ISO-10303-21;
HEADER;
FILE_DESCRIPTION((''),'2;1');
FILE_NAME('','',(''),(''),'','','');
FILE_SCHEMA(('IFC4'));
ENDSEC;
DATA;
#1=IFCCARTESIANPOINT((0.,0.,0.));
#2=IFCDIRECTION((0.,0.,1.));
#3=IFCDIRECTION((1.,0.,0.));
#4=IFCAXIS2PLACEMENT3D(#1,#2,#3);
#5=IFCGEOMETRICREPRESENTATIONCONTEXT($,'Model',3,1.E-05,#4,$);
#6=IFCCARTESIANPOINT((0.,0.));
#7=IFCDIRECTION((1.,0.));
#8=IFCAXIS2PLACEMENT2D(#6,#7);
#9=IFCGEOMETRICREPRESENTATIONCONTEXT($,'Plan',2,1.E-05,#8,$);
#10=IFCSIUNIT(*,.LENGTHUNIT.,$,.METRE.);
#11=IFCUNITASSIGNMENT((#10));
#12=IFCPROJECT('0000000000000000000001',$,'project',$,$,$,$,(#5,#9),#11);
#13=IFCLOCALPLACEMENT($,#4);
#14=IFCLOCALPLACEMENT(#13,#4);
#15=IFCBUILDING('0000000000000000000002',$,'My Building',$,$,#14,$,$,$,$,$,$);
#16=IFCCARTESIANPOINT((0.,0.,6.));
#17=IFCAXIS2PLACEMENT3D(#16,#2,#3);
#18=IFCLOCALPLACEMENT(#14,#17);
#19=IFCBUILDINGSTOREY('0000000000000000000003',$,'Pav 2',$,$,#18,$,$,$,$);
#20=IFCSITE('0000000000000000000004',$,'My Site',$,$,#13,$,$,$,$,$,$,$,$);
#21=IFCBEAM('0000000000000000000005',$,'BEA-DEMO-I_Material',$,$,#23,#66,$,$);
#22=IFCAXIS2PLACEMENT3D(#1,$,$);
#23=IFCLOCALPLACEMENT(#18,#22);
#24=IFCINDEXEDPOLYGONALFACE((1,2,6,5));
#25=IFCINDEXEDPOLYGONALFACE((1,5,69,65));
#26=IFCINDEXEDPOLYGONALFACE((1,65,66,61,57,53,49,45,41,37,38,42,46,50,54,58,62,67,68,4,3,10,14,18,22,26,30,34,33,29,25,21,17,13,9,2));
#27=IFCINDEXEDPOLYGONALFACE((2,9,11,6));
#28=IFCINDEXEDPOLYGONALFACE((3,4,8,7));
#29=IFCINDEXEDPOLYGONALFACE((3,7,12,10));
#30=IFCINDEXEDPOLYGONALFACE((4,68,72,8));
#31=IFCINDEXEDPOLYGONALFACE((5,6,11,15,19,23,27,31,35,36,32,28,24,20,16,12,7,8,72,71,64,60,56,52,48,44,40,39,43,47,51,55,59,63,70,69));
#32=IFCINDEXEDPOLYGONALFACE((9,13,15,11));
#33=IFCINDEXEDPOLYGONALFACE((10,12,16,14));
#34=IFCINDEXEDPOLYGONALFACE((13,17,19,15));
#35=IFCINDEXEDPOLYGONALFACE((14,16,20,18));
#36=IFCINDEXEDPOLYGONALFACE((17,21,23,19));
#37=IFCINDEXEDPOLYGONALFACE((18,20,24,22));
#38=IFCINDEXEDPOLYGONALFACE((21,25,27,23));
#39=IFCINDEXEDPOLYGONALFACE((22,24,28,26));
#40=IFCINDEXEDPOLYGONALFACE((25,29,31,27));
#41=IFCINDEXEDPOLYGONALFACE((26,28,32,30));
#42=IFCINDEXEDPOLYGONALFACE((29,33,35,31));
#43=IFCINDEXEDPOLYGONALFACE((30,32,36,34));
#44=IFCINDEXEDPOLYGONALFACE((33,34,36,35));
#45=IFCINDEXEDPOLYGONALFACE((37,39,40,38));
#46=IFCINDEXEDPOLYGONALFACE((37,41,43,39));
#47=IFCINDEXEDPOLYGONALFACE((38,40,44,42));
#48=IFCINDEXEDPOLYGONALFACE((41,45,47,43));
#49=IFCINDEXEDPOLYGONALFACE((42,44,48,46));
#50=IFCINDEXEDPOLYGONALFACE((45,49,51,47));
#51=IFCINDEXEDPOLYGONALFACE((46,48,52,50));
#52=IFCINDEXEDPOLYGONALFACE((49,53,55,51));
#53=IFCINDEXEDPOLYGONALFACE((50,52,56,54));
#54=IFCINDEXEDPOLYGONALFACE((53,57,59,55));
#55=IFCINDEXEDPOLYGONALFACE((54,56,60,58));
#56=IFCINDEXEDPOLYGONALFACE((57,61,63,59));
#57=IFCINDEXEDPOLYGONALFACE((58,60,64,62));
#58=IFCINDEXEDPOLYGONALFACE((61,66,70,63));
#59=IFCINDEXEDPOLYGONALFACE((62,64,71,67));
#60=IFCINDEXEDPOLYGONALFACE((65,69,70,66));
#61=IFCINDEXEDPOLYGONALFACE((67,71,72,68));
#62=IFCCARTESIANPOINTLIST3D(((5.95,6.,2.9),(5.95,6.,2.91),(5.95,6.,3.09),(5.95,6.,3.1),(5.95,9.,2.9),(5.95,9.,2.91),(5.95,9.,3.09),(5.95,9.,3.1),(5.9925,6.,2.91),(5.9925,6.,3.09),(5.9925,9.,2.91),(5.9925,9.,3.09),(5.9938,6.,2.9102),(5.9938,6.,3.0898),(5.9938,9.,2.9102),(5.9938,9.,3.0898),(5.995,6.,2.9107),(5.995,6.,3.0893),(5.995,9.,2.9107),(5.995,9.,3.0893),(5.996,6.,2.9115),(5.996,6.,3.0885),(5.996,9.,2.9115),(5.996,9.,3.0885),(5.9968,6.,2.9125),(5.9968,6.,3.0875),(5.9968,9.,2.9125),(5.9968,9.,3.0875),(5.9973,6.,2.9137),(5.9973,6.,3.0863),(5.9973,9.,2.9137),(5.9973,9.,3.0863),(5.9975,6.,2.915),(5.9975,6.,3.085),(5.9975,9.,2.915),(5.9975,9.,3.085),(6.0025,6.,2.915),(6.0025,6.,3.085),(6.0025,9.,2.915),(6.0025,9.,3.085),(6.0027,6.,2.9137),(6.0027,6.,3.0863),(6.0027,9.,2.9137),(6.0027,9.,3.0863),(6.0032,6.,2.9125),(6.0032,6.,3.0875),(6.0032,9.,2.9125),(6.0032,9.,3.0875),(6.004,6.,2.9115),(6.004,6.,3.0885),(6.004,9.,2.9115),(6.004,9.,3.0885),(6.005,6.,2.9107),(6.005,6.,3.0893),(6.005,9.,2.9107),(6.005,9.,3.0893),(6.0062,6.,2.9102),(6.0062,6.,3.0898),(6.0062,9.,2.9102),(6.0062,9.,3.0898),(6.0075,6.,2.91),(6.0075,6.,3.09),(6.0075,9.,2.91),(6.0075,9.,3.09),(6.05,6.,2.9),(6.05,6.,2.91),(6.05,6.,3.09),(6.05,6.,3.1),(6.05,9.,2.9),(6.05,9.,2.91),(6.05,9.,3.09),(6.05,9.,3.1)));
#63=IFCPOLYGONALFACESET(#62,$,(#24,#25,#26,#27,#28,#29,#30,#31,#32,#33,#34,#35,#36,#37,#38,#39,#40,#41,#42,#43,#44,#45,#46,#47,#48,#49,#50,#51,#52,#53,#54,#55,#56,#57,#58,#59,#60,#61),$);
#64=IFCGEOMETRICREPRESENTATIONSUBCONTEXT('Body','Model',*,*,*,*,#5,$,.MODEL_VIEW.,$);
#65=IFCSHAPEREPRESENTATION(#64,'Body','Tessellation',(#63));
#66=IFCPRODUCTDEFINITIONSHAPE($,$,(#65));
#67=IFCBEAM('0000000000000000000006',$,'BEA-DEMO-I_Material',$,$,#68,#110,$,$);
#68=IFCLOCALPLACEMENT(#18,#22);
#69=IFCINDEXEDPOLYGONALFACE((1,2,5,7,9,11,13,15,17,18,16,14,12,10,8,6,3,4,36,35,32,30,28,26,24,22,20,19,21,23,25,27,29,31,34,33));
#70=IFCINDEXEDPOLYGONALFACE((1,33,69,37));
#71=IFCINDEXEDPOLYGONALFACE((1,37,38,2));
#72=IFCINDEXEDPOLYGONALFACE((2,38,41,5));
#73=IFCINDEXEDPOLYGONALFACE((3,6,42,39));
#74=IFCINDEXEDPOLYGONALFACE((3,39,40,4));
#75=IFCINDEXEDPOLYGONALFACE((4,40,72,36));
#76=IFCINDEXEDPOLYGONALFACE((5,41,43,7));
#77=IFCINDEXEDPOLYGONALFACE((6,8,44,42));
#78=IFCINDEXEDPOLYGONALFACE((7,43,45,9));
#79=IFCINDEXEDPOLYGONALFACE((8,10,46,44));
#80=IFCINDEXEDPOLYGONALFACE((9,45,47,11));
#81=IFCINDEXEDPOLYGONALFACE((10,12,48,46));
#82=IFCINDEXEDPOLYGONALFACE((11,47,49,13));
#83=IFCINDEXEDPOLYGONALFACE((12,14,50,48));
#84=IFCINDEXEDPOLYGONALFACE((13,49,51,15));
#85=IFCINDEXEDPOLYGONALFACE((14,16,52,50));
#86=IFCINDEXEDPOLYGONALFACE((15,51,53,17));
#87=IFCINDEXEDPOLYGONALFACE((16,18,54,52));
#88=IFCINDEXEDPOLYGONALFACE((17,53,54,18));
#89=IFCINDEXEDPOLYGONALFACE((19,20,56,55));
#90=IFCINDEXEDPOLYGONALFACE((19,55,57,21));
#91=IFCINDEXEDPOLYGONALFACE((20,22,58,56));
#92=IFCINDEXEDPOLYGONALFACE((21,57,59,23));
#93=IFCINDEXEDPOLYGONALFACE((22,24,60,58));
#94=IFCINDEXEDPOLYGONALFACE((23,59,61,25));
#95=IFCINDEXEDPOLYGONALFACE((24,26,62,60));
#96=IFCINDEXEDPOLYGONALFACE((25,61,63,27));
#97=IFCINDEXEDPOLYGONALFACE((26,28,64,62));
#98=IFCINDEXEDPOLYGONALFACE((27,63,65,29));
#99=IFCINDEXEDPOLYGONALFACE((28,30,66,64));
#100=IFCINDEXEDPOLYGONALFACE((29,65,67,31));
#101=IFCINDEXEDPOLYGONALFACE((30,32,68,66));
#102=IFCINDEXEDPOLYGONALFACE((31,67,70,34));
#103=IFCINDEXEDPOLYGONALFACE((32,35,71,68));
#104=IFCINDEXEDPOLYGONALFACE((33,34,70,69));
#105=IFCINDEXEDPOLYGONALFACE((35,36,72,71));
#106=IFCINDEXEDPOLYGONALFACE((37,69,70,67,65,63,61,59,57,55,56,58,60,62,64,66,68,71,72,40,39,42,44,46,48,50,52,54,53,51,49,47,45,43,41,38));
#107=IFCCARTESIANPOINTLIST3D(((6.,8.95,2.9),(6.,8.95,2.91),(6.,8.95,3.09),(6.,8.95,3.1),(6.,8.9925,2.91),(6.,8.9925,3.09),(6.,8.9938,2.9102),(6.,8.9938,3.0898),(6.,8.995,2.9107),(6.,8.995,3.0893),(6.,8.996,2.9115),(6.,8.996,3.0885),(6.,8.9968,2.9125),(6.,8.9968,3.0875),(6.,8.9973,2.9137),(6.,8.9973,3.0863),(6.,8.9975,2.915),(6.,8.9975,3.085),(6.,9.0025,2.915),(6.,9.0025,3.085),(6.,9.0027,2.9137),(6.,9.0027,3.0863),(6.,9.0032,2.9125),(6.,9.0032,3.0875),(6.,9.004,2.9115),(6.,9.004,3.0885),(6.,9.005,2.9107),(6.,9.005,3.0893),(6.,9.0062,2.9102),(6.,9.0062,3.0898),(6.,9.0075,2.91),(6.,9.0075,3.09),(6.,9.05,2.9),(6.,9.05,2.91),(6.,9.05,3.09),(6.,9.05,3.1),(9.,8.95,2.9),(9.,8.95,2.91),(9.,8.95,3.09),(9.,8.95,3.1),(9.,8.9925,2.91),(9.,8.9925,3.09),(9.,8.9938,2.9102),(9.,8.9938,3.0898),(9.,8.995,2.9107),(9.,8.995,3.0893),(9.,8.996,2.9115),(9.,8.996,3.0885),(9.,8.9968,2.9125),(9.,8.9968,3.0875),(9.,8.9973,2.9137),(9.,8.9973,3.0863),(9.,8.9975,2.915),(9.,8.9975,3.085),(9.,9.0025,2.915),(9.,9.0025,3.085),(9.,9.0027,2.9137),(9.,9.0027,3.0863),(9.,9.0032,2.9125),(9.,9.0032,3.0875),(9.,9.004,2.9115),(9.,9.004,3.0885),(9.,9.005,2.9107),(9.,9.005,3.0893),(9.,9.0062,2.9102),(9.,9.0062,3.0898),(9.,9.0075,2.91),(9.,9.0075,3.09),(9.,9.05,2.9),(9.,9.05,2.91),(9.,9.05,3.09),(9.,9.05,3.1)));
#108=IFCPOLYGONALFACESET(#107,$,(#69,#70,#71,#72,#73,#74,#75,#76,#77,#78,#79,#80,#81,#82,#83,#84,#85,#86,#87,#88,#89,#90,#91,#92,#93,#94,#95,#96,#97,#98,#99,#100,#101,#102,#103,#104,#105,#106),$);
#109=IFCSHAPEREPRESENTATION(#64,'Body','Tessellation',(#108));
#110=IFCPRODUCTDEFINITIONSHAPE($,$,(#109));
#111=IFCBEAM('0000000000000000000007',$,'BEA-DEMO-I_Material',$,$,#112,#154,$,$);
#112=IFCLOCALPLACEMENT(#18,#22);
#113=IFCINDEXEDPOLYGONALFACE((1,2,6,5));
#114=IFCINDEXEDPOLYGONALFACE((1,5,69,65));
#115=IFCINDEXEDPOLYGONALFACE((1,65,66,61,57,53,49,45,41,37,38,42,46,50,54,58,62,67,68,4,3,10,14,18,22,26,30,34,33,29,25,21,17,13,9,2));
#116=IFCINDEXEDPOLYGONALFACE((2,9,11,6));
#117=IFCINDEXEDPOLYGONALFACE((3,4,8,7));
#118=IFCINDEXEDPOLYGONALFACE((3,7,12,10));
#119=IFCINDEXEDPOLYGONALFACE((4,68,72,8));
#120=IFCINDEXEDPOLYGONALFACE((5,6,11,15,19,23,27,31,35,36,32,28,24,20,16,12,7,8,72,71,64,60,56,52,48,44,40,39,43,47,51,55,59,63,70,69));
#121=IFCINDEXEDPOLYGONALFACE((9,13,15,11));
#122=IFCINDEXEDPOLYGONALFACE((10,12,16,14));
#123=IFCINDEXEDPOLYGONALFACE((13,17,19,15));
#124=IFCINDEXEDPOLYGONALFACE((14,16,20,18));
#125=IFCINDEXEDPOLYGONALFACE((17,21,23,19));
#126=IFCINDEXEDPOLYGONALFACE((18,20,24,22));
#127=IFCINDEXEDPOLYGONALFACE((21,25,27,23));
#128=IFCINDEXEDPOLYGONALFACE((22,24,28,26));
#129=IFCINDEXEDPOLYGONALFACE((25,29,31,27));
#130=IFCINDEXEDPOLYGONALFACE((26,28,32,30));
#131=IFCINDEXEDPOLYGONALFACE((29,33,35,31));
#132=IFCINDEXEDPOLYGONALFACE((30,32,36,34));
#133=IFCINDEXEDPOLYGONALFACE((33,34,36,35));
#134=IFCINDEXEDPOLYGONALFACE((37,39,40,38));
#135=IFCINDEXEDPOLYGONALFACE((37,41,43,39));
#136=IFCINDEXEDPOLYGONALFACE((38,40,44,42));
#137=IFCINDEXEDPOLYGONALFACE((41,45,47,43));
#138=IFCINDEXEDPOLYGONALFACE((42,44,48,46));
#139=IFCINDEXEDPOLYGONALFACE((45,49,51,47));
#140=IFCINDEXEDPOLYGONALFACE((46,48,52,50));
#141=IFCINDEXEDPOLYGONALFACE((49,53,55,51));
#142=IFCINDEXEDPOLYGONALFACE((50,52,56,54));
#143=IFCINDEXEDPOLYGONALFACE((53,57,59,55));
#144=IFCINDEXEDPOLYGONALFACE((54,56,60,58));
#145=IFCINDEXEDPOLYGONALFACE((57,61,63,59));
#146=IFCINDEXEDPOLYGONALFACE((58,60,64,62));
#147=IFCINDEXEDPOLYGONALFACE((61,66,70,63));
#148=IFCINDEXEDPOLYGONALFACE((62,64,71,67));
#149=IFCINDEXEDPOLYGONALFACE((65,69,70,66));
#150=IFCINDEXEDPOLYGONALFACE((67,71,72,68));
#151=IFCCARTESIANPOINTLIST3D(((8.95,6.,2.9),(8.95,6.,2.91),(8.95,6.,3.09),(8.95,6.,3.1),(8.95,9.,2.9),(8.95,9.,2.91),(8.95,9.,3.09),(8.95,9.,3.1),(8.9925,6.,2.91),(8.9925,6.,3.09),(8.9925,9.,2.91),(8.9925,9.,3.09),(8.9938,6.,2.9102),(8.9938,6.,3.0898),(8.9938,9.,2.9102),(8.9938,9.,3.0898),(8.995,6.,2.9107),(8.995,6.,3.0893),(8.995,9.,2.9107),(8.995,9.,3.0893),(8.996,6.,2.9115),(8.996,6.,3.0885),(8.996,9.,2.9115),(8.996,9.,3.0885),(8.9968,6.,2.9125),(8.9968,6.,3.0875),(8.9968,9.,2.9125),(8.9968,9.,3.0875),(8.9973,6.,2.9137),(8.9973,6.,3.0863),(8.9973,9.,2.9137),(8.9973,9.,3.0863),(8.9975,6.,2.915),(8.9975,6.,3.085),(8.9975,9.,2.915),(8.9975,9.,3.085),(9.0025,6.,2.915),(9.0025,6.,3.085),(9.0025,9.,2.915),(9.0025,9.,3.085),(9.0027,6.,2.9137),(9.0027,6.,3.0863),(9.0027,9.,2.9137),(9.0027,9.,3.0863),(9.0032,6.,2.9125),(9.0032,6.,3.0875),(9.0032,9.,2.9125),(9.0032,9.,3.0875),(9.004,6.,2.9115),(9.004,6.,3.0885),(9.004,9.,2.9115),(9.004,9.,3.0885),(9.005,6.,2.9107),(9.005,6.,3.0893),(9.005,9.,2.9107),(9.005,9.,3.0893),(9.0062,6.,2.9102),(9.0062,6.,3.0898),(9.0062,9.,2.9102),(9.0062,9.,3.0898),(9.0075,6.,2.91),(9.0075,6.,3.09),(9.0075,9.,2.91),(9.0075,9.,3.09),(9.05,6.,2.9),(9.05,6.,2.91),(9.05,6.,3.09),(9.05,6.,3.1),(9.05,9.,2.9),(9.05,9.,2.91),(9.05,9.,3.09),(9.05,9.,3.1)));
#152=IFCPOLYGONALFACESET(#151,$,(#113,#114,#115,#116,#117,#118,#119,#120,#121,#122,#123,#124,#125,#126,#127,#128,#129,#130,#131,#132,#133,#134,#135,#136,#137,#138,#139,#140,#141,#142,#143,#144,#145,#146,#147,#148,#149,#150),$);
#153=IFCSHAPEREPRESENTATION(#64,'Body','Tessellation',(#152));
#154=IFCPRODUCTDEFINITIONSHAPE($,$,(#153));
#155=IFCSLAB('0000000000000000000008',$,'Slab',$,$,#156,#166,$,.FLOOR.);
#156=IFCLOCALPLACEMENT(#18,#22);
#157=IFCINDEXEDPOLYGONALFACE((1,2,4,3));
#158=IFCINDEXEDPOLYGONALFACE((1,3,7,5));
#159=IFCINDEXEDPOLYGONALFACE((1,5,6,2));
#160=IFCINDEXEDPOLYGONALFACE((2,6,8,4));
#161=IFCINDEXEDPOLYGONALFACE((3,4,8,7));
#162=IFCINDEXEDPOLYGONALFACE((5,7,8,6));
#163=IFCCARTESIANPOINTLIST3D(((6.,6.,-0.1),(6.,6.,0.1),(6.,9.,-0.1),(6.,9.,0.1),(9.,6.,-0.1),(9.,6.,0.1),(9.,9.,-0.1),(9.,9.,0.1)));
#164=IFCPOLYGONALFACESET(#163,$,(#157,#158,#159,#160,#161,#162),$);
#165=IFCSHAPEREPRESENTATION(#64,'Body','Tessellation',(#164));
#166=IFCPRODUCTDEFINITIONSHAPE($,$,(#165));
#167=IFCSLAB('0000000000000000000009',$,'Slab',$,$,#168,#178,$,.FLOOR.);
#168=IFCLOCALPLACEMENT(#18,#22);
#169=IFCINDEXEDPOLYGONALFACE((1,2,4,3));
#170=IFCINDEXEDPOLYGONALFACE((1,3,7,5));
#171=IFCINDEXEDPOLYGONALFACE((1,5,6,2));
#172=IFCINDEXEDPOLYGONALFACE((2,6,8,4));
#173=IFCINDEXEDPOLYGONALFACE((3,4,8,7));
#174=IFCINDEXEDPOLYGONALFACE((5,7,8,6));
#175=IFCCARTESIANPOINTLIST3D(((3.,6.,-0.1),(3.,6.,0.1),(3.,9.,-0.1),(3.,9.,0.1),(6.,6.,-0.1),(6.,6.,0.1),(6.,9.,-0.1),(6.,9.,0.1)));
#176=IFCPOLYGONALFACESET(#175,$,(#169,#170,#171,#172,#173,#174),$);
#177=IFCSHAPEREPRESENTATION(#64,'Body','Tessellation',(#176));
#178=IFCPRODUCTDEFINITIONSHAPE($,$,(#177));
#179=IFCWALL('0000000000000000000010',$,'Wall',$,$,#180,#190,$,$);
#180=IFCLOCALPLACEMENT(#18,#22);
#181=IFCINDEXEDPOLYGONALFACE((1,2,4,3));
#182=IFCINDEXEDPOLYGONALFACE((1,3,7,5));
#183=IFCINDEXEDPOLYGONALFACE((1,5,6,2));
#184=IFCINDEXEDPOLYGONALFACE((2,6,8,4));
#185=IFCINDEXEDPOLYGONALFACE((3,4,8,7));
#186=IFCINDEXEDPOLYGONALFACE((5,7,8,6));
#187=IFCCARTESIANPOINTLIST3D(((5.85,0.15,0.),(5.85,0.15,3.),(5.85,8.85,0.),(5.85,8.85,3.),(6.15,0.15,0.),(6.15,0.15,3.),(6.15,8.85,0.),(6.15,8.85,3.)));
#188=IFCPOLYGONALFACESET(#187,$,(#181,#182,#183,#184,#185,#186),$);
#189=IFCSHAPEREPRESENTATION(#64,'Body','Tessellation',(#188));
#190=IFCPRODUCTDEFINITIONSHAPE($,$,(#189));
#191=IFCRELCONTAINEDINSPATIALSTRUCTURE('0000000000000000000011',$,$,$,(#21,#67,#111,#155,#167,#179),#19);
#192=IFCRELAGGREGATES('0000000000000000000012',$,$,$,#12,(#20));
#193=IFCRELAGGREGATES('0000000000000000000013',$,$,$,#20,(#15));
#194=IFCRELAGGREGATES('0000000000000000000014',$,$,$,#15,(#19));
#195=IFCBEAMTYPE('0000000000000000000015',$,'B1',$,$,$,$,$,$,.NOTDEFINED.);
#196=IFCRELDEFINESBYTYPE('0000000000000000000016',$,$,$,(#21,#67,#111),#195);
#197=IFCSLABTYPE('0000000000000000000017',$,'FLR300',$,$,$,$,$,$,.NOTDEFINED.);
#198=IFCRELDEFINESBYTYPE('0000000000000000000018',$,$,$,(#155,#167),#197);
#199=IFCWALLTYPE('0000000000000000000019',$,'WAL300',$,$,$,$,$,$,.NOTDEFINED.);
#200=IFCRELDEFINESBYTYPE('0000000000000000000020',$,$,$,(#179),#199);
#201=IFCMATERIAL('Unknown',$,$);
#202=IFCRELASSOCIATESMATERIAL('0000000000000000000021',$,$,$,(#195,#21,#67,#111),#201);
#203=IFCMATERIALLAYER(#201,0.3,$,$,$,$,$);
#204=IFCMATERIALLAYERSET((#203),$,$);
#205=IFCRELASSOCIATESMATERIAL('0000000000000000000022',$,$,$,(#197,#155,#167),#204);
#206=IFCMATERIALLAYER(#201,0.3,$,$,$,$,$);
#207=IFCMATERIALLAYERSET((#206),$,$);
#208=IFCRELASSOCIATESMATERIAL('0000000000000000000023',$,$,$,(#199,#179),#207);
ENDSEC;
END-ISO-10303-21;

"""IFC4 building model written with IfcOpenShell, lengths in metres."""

from ifc_helpers import new_model, si_unit, frame, origin, origin_with_axes, origin_2d_with_axis, place, context, subcontext, project, spatial, polyline, line, indexed_curve, i_section, outline, extrude, material, layer, layer_set, layer_usage, material_profile, profile_set, profile_usage, type_object, element, save


model = new_model("IFC4")

# Units and contexts
model_context = context("Model", 3, precision=1e-05, world=origin_with_axes())
plan_context = context("Plan", 2, precision=1e-05, world=origin_2d_with_axis())
body_context = subcontext(model_context, "Body", "Model", "MODEL_VIEW")
ifc_project = project(units=[si_unit("LENGTHUNIT", "METRE")], contexts=[model_context, plan_context])

# Site, building, storey
site_placement = place(None, origin_with_axes())
site = spatial("IfcSite", under=ifc_project, at=site_placement, Name="My Site")
building_placement = place(site_placement, origin_with_axes())
building = spatial("IfcBuilding", under=site, at=building_placement, Name="My Building")
storey_placement = place(building_placement, frame((0.0, 0.0, 6.0), z_axis=(0.0, 0.0, 1.0), x_axis=(1.0, 0.0, 0.0)))
storey = spatial("IfcBuildingStorey", under=building, at=storey_placement, Name="Pav 2")

# Beams
ifc_material = material(Name="Unknown")
ifc_material_profile = material_profile(ifc_material, i_section(OverallWidth=0.1, OverallDepth=0.2, WebThickness=0.005, FlangeThickness=0.01, FilletRadius=0.005))
ifc_profile_set = profile_set([ifc_material_profile])
beam_type = type_object("IfcBeamType", Name="B1", PredefinedType="NOTDEFINED", material=ifc_profile_set)
ifc_profile_usage_1 = profile_usage(ifc_profile_set, cardinal=5)
beam_1_placement = place(storey_placement, frame((6.0, 9.0, 3.0), z_axis=(0.0, -1.0, 0.0), x_axis=(1.0, 0.0, 0.0)))
element("IfcBeam", 1, at=beam_1_placement, inside=storey, type_object=beam_type, material=ifc_profile_usage_1, Name="BEA-DEMO-I_Material", context=body_context, shape_type="SweptSolid", body=[
    extrude(i_section(OverallWidth=0.1, OverallDepth=0.2, WebThickness=0.005, FlangeThickness=0.01, FilletRadius=0.005), origin(), (0.0, 0.0, 1.0), 3.0),
])
ifc_profile_usage_2 = profile_usage(ifc_profile_set, cardinal=5)
beam_2_placement = place(storey_placement, frame((6.0, 9.0, 3.0), z_axis=(1.0, 0.0, 0.0), x_axis=(0.0, 1.0, 0.0)))
element("IfcBeam", 2, at=beam_2_placement, inside=storey, type_object=beam_type, material=ifc_profile_usage_2, Name="BEA-DEMO-I_Material", context=body_context, shape_type="SweptSolid", body=[
    extrude(i_section(OverallWidth=0.1, OverallDepth=0.2, WebThickness=0.005, FlangeThickness=0.01, FilletRadius=0.005), origin(), (0.0, 0.0, 1.0), 3.0),
])
ifc_profile_usage_3 = profile_usage(ifc_profile_set, cardinal=5)
beam_3_placement = place(storey_placement, frame((9.0, 9.0, 3.0), z_axis=(0.0, -1.0, 0.0), x_axis=(1.0, 0.0, 0.0)))
element("IfcBeam", 3, at=beam_3_placement, inside=storey, type_object=beam_type, material=ifc_profile_usage_3, Name="BEA-DEMO-I_Material", context=body_context, shape_type="SweptSolid", body=[
    extrude(i_section(OverallWidth=0.1, OverallDepth=0.2, WebThickness=0.005, FlangeThickness=0.01, FilletRadius=0.005), origin(), (0.0, 0.0, 1.0), 3.0),
])

# Slabs
ifc_layer_1 = layer(ifc_material, 0.3)
ifc_layer_set_1 = layer_set([ifc_layer_1])
ifc_layer_usage_1 = layer_usage(ifc_layer_set_1, "AXIS3", "POSITIVE", 0.0)
slab_type = type_object("IfcSlabType", Name="FLR300", PredefinedType="NOTDEFINED", material=ifc_layer_set_1)
slab_1_placement = place(storey_placement, frame((7.5, 7.5, -0.1), z_axis=(0.0, 0.0, 1.0), x_axis=(1.0, 0.0, 0.0)))
element("IfcSlab", 4, at=slab_1_placement, inside=storey, type_object=slab_type, material=ifc_layer_usage_1, Name="Slab", PredefinedType="FLOOR", context=body_context, shape_type="SweptSolid", body=[
    extrude(outline(polyline([(1.5, 1.5), (-1.5, 1.5), (-1.5, -1.5), (1.5, -1.5), (1.5, 1.5)])), origin(), (0.0, 0.0, 1.0), 0.2),
])
ifc_layer_usage_2 = layer_usage(ifc_layer_set_1, "AXIS3", "POSITIVE", 0.0)
slab_2_placement = place(storey_placement, frame((4.5, 7.5, -0.1), z_axis=(0.0, 0.0, 1.0), x_axis=(1.0, 0.0, 0.0)))
element("IfcSlab", 5, at=slab_2_placement, inside=storey, type_object=slab_type, material=ifc_layer_usage_2, Name="Slab", PredefinedType="FLOOR", context=body_context, shape_type="SweptSolid", body=[
    extrude(outline(polyline([(1.5, 1.5), (-1.5, 1.5), (-1.5, -1.5), (1.5, -1.5), (1.5, 1.5)])), origin(), (0.0, 0.0, 1.0), 0.2),
])

# Wall
ifc_layer_2 = layer(ifc_material, 0.3)
ifc_layer_set_2 = layer_set([ifc_layer_2])
ifc_layer_usage_3 = layer_usage(ifc_layer_set_2, "AXIS2", "POSITIVE", -0.15)
wall_type = type_object("IfcWallType", Name="WAL300", PredefinedType="NOTDEFINED", material=ifc_layer_set_2)
wall_1_placement = place(storey_placement, frame((6.0, 9.0, 0.0), z_axis=(0.0, 0.0, 1.0), x_axis=(0.0, -1.0, 0.0)))
element("IfcWall", 6, at=wall_1_placement, inside=storey, type_object=wall_type, material=ifc_layer_usage_3, Name="Wall", context=body_context, shape_type="SweptSolid", body=[
    extrude(outline(indexed_curve([(0.15, -0.15), (0.15, 0.15), (8.85, 0.15), (8.85, -0.15)], segments=[line(1, 2, 3, 4, 1)])), origin_with_axes(), (0.0, 0.0, 1.0), 3.0),
])

save(model, "model.ifc")
